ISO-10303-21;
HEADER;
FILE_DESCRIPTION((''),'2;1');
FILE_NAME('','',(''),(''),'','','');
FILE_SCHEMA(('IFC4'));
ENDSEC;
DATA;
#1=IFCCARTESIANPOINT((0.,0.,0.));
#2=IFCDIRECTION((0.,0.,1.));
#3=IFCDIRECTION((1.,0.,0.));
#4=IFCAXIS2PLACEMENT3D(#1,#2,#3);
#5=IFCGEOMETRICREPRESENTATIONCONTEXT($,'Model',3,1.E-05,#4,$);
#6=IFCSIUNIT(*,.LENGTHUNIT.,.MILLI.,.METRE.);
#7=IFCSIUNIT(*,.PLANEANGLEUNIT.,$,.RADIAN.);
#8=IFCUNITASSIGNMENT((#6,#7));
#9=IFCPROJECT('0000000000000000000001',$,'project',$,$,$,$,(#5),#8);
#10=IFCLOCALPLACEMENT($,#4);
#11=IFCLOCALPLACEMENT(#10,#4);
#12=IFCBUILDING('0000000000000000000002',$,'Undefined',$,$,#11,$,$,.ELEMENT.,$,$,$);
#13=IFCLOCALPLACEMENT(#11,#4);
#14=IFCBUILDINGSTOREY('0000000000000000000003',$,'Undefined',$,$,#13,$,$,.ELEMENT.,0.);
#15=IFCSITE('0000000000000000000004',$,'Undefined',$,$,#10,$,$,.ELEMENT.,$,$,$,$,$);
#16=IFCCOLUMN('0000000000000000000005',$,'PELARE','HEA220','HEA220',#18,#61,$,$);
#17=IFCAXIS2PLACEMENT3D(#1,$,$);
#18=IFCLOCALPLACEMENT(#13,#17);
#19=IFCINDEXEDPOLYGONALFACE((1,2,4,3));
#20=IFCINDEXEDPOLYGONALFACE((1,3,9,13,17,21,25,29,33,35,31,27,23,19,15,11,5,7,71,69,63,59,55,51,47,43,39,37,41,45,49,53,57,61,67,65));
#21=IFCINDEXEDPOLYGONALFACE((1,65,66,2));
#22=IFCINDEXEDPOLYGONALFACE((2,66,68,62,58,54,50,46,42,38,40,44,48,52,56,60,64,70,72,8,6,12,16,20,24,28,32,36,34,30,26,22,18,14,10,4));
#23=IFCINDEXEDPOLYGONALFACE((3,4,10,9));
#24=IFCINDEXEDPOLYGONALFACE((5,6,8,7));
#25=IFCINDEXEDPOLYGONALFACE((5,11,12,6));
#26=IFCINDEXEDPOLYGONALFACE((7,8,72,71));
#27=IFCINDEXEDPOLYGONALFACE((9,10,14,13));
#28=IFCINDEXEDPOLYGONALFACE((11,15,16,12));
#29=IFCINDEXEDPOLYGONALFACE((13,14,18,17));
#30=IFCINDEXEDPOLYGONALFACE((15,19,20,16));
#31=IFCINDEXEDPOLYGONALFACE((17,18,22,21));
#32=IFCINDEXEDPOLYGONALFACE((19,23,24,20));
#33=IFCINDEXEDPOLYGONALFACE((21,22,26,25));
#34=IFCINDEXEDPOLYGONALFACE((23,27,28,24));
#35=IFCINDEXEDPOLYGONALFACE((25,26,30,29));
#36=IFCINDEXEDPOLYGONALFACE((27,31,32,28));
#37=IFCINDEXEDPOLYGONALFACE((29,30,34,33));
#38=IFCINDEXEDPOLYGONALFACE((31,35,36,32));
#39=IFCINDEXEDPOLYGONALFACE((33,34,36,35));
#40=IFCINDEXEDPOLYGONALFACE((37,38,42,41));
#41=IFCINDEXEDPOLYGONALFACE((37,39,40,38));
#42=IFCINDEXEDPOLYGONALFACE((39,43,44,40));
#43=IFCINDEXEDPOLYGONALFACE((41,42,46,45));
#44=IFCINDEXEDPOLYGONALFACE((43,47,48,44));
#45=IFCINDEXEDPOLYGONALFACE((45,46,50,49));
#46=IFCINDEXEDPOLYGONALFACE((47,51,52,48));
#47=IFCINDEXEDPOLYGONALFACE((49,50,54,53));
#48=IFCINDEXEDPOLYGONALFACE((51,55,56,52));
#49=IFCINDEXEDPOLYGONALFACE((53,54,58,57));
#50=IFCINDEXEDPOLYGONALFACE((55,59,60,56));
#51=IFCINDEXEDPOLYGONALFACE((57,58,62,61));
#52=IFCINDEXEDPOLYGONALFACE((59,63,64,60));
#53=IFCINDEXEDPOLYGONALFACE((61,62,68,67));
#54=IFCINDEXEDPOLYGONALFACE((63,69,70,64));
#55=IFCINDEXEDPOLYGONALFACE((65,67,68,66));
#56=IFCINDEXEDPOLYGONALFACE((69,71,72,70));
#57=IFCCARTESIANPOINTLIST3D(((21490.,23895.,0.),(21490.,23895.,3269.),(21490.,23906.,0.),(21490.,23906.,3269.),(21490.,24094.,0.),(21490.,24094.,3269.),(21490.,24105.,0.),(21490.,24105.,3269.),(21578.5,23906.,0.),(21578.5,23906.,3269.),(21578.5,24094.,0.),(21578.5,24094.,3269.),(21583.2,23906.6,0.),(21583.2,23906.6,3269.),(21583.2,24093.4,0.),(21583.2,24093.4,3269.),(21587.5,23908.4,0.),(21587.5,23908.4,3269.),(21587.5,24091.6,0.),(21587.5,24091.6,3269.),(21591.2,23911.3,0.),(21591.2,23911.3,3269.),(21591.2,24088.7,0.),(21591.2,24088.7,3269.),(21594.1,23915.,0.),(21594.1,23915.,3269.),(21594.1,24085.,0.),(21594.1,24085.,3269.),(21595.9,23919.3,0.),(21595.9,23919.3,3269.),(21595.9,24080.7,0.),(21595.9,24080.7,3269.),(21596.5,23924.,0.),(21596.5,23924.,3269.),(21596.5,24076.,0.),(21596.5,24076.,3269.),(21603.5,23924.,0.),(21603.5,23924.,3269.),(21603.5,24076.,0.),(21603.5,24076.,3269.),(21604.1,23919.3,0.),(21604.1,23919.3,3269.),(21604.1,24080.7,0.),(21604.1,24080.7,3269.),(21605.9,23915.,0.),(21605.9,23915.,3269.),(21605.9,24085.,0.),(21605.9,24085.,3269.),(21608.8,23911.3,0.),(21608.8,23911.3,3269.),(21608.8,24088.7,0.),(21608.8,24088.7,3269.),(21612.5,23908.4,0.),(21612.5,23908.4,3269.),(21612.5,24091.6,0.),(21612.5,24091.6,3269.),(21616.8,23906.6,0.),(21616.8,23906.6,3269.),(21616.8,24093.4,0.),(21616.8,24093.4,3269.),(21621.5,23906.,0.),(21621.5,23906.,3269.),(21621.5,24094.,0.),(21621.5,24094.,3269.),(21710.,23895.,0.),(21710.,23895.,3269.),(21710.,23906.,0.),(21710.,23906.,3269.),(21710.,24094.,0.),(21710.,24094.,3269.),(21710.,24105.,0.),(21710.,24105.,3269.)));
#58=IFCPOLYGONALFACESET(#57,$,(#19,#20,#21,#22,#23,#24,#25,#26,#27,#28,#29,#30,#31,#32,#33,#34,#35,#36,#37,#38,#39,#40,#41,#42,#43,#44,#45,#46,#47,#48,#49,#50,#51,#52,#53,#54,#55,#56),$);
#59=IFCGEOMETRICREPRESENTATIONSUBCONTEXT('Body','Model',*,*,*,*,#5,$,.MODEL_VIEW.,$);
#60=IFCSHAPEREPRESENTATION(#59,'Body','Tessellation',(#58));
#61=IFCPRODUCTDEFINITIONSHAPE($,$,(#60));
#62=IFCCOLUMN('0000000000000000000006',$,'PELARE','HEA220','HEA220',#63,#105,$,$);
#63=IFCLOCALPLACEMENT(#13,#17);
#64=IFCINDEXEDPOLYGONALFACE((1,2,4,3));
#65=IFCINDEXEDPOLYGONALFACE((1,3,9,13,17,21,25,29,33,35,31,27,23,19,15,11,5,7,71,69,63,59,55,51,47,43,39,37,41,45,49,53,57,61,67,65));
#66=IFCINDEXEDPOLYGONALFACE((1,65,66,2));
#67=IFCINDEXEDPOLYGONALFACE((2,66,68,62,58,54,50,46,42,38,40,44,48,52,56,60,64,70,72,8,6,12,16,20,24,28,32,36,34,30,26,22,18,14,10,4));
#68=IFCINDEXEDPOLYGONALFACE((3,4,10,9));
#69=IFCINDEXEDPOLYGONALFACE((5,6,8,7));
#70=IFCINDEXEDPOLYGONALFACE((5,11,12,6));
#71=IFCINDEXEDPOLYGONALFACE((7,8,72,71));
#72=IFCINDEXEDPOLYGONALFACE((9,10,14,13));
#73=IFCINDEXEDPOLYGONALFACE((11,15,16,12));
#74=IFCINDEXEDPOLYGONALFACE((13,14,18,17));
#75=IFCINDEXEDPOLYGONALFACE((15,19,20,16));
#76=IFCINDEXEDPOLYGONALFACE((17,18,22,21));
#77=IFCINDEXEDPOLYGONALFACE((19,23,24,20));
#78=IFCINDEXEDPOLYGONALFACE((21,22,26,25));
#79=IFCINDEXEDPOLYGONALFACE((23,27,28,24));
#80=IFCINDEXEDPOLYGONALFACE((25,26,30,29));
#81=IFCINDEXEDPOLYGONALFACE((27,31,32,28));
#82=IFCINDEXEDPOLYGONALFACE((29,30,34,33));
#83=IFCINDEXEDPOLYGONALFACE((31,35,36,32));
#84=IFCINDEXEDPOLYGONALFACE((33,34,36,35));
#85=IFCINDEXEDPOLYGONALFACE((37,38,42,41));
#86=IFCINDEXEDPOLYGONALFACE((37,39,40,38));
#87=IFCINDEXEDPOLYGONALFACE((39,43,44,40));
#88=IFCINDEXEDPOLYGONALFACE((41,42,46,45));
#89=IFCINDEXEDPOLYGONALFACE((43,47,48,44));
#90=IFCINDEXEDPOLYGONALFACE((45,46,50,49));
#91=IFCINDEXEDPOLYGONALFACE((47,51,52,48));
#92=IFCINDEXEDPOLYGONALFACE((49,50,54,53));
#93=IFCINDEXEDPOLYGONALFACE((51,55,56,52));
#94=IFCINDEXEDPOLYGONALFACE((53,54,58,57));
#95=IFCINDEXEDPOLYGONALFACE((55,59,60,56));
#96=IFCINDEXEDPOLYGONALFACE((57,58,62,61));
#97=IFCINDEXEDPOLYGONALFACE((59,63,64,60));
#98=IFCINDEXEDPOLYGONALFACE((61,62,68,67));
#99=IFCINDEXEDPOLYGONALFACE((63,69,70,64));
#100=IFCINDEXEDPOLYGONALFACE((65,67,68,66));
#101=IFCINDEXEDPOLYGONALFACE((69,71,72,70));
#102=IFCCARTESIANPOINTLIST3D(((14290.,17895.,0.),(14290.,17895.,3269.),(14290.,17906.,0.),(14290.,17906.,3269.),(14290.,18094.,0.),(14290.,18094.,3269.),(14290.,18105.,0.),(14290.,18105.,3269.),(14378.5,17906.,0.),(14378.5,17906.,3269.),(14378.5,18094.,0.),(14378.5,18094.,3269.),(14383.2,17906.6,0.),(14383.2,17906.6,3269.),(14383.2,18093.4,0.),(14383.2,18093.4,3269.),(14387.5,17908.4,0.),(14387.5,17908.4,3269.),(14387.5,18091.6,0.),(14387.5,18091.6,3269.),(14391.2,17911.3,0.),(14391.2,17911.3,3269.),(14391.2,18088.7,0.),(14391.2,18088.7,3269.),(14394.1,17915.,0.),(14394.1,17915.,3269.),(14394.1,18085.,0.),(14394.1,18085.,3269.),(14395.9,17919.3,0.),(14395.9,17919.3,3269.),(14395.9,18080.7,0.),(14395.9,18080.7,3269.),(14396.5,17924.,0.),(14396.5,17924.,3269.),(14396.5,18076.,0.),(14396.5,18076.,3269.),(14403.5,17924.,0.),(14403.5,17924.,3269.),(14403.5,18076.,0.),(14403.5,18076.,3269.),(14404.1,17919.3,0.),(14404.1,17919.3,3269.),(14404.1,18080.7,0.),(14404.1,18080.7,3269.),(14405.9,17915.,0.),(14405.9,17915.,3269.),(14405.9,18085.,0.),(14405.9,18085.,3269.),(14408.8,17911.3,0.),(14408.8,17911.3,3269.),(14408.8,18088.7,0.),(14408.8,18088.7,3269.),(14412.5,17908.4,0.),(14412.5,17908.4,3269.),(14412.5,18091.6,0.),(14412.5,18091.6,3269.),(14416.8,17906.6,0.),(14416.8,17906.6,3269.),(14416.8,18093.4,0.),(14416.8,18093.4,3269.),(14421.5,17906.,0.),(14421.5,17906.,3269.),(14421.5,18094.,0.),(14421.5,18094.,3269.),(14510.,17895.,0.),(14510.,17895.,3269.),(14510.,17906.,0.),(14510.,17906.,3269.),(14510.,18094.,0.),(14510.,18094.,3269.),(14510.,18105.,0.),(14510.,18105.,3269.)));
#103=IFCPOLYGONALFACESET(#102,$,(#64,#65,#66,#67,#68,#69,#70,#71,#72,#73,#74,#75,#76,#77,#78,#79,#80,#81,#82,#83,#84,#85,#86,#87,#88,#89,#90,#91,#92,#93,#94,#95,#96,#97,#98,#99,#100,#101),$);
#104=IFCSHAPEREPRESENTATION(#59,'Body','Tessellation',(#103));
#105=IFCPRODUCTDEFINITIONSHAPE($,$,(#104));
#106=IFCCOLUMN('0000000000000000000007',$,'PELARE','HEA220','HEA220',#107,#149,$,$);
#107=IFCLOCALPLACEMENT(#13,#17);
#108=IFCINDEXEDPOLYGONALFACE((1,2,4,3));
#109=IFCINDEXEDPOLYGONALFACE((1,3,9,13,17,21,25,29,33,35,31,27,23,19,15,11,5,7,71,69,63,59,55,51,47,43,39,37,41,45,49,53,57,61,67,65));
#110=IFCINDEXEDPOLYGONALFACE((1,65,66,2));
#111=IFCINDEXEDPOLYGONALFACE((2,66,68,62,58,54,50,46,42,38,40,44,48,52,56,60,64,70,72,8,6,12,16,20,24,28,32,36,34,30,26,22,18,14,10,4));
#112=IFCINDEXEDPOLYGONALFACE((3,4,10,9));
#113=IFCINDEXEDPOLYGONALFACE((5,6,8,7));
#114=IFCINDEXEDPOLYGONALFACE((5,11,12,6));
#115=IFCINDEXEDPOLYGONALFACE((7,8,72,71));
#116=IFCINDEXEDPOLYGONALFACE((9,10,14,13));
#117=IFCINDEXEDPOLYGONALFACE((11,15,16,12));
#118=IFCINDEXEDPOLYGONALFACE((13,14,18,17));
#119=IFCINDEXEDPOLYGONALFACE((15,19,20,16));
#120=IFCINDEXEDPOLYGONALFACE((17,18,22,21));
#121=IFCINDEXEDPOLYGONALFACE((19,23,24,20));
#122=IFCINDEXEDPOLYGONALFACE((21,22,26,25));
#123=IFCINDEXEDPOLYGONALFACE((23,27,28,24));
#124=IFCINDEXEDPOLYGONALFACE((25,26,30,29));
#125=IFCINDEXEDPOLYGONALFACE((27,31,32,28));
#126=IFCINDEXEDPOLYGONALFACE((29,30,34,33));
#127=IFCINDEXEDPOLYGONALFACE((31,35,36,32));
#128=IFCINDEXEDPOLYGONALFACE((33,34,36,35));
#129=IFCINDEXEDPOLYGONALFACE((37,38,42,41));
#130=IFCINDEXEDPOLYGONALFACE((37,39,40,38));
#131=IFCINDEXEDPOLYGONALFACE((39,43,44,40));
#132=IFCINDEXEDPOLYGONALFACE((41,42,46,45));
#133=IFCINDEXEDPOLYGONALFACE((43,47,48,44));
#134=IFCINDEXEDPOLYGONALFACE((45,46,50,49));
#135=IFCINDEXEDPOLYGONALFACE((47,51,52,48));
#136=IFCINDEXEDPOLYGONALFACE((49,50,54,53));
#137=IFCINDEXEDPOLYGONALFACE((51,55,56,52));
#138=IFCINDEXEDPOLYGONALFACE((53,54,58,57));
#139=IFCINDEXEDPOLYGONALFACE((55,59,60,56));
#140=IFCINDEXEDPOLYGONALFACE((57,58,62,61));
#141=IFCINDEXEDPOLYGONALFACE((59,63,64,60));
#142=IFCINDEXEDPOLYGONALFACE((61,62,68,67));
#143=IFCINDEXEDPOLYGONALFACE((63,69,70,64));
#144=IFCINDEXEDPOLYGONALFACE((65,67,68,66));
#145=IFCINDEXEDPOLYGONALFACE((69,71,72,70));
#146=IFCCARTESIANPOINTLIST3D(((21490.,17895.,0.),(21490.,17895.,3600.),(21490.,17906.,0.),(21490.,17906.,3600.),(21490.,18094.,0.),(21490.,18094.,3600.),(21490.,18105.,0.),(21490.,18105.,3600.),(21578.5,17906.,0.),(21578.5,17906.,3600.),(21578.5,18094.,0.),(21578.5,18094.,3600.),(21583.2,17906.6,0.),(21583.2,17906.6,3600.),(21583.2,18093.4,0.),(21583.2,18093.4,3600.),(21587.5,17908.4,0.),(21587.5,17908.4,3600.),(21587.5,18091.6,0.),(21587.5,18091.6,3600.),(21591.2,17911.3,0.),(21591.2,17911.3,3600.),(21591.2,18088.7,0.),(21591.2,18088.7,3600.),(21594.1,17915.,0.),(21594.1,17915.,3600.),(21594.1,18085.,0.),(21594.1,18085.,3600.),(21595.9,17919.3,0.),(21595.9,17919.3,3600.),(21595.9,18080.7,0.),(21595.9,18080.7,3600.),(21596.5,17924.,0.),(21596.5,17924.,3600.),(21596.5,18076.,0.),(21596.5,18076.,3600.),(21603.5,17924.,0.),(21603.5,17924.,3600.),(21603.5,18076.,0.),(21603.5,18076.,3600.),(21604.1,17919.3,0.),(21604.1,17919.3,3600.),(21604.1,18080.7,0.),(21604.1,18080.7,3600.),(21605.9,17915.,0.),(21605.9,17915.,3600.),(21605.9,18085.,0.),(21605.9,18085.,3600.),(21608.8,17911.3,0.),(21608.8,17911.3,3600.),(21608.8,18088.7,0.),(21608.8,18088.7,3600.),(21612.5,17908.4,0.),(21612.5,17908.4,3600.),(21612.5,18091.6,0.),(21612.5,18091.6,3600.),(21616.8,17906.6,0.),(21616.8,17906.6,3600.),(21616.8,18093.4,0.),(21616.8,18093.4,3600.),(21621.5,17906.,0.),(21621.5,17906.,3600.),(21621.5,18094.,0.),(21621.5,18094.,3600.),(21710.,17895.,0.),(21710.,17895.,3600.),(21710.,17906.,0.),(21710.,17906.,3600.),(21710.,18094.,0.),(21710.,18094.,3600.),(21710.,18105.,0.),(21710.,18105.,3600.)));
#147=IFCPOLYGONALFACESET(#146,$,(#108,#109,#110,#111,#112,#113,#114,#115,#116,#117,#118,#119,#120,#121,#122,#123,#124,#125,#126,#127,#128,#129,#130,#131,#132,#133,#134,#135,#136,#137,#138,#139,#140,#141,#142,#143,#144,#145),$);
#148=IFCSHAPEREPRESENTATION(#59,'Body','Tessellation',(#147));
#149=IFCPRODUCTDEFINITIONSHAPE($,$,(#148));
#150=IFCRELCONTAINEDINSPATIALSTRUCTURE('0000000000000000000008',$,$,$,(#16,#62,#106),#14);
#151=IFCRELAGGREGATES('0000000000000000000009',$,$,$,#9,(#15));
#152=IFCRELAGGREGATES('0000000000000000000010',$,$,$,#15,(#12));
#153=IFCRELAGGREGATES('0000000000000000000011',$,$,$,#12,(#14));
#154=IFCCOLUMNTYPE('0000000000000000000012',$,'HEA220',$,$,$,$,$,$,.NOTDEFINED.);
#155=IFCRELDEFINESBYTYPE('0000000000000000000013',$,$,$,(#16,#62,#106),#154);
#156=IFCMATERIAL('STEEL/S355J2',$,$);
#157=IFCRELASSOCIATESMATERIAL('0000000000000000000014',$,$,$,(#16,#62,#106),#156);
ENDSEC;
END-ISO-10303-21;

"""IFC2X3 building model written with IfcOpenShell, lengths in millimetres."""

from ifc_helpers import new_model, si_unit, frame, origin_with_axes, origin_2d_with_axis, place, context, subcontext, project, spatial, i_section, extrude, clip, halfspace, material, type_object, element, save


model = new_model("IFC2X3")

# Units and contexts
model_context = context("Model", 3, precision=1e-05, world=origin_with_axes())
body_context = subcontext(model_context, "Body", "Model", "MODEL_VIEW")
ifc_project = project(units=[si_unit("LENGTHUNIT", "METRE", prefix="MILLI"), si_unit("PLANEANGLEUNIT", "RADIAN")], contexts=[model_context])

# Site, building, storey
site_placement = place(None, origin_with_axes())
site = spatial("IfcSite", under=ifc_project, at=site_placement, Name="Undefined", CompositionType="ELEMENT")
building_placement = place(site_placement, origin_with_axes())
building = spatial("IfcBuilding", under=site, at=building_placement, Name="Undefined", CompositionType="ELEMENT")
storey_placement = place(building_placement, origin_with_axes())
storey = spatial("IfcBuildingStorey", under=building, at=storey_placement, Name="Undefined", CompositionType="ELEMENT", Elevation=0.0)

# Columns
ifc_material_1 = material(Name="STEEL/S355J2")
column_type_1 = type_object("IfcColumnType", Name="HEA220", PredefinedType="NOTDEFINED")
for number, where, z_axis, x_axis, name in (
    (1, (21600.0, 24000.0, 0.0), (0.0, 0.0, 1.0), (0.0, 1.0, 0.0), "PELARE"),
    (2, (14400.0, 18000.0, 0.0), (0.0, 0.0, 1.0), (0.0, 1.0, 0.0), "PELARE"),
):
    element("IfcColumn", number, at=place(storey_placement, frame(where, z_axis=z_axis, x_axis=x_axis)), inside=storey, type_object=column_type_1, material=ifc_material_1, Name=name, Description="HEA220", ObjectType="HEA220", context=body_context, shape_type="Clipping", body=[
        clip(extrude(i_section(OverallWidth=220.0, OverallDepth=210.0, WebThickness=7.0, FlangeThickness=11.0, FilletRadius=18.0, at=origin_2d_with_axis()), frame((0.0, 0.0, 3269.0), z_axis=(0.0, 0.0, -1.0), x_axis=(0.0, 1.0, 0.0)), (0.0, 0.0, 1.0), 3269.0), halfspace(frame((160.0, 0.0, 3269.0), z_axis=(0.0, 0.0, 1.0), x_axis=(0.0, -1.0, 0.0)), False)),
    ])
column_1_placement = place(storey_placement, frame((21600.0, 18000.0, 0.0), z_axis=(0.0, 0.0, 1.0), x_axis=(0.0, 1.0, 0.0)))
element("IfcColumn", 3, at=column_1_placement, inside=storey, type_object=column_type_1, material=ifc_material_1, Name="PELARE", Description="HEA220", ObjectType="HEA220", context=body_context, shape_type="SweptSolid", body=[
    extrude(i_section(OverallWidth=220.0, OverallDepth=210.0, WebThickness=7.0, FlangeThickness=11.0, FilletRadius=18.0, at=origin_2d_with_axis()), frame((0.0, 0.0, 3600.0), z_axis=(0.0, 0.0, -1.0), x_axis=(0.0, 1.0, 0.0)), (0.0, 0.0, 1.0), 3600.0),
])

save(model, "model.ifc")
